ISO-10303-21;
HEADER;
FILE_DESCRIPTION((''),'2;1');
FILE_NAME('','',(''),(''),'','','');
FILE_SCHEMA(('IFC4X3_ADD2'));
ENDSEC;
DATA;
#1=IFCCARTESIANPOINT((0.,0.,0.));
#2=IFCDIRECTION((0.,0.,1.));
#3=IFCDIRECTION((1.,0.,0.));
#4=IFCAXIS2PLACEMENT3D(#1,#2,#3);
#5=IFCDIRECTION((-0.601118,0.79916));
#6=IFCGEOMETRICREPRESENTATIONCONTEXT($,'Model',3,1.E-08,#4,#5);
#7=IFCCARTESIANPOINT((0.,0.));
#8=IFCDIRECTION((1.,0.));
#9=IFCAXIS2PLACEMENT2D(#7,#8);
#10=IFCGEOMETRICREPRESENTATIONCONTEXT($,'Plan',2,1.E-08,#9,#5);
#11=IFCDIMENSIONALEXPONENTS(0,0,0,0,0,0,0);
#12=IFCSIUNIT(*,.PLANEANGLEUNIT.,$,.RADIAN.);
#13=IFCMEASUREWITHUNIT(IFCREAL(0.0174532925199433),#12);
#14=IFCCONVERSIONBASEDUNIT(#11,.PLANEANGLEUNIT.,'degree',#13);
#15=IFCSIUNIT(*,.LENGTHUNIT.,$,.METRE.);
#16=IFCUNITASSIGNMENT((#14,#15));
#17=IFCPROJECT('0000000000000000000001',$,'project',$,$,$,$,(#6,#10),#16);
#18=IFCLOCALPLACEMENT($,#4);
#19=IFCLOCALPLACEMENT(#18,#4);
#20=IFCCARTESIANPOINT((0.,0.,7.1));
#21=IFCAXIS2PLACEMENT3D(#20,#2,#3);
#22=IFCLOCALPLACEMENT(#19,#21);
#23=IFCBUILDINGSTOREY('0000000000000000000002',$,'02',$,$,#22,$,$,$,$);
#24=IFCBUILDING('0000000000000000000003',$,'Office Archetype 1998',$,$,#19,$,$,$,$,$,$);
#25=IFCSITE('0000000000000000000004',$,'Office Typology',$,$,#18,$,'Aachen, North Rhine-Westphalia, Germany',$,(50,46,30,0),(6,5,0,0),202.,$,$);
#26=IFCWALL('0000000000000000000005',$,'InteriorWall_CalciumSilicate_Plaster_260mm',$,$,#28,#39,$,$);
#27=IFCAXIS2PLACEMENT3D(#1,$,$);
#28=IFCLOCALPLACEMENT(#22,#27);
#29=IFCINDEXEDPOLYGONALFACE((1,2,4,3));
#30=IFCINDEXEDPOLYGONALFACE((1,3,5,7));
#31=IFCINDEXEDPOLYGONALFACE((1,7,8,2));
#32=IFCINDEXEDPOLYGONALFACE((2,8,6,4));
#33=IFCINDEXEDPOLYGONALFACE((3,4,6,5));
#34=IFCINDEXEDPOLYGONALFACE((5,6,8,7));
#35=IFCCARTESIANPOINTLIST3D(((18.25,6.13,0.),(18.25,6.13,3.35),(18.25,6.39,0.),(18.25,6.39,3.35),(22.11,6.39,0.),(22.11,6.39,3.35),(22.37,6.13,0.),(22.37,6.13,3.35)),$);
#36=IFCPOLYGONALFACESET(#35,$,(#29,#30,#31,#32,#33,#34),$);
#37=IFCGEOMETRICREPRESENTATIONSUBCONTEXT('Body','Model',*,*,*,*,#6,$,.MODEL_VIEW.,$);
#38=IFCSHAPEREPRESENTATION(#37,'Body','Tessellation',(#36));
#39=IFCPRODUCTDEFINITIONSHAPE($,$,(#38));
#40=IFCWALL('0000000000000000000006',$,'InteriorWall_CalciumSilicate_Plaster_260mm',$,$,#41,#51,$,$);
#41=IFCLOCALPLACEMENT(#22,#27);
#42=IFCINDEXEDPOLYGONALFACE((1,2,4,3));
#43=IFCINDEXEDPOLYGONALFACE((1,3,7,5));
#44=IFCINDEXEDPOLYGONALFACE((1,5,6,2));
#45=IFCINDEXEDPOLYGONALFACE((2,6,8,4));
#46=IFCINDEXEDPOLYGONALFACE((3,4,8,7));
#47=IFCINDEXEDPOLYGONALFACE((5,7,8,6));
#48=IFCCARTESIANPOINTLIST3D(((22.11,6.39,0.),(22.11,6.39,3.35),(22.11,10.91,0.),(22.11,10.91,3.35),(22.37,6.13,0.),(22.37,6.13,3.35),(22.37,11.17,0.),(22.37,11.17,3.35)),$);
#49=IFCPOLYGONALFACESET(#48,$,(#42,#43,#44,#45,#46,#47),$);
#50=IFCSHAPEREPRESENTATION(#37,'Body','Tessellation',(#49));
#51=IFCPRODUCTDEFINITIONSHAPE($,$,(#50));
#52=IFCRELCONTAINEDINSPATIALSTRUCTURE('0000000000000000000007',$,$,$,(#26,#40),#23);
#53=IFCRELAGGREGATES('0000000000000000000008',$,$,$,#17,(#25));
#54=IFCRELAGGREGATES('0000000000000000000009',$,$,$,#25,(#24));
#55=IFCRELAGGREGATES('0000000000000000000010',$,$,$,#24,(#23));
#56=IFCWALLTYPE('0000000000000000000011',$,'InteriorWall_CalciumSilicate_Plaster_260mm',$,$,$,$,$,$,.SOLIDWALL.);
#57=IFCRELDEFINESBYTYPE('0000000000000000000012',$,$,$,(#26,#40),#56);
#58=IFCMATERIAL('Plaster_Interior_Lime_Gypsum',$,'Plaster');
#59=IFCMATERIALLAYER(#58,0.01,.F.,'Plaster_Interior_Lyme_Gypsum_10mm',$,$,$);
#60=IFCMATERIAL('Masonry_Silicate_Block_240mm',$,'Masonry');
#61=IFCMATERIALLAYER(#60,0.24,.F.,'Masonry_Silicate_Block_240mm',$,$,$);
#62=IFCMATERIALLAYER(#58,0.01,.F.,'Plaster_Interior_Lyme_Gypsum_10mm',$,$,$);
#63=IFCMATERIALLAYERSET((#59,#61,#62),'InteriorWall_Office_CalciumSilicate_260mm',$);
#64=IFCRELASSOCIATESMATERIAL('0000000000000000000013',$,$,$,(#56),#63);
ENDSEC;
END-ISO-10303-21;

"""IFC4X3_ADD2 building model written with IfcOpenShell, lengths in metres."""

from ifc_helpers import new_model, entity, si_unit, converted_unit, direction, frame, origin_with_axes, origin_2d_with_axis, place, context, subcontext, project, spatial, line, indexed_curve, outline, extrude, material, layer, layer_set, type_object, element, save


model = new_model("IFC4X3_ADD2")

# Units and contexts
model_context = context("Model", 3, precision=1e-08, world=origin_with_axes(), true_north=direction((-0.601118, 0.79916)))
plan_context = context("Plan", 2, precision=1e-08, world=origin_2d_with_axis(), true_north=direction((-0.601118, 0.79916)))
body_context = subcontext(model_context, "Body", "Model", "MODEL_VIEW")
ifc_project = project(units=[converted_unit("PLANEANGLEUNIT", "degree", entity("IfcReal", 0.0174532925199433), si_unit("PLANEANGLEUNIT", "RADIAN"), dimensions=[0, 0, 0, 0, 0, 0, 0]), si_unit("LENGTHUNIT", "METRE")], contexts=[model_context, plan_context])

# Site, building, storey
site_placement = place(None, origin_with_axes())
site = spatial("IfcSite", under=ifc_project, at=site_placement, Name="Office Typology", LongName="Aachen, North Rhine-Westphalia, Germany", RefLatitude=(50, 46, 30, 0), RefLongitude=(6, 5, 0, 0), RefElevation=202.0)
building_placement = place(site_placement, origin_with_axes())
building = spatial("IfcBuilding", under=site, at=building_placement, Name="Office Archetype 1998")
storey_placement = place(building_placement, frame((0.0, 0.0, 7.1), z_axis=(0.0, 0.0, 1.0), x_axis=(1.0, 0.0, 0.0)))
storey = spatial("IfcBuildingStorey", under=building, at=storey_placement, Name="02")

# Wall
ifc_material_1 = material(Name="Plaster_Interior_Lime_Gypsum", Category="Plaster")
ifc_layer_1 = layer(ifc_material_1, 0.01, ventilated=False, Name="Plaster_Interior_Lyme_Gypsum_10mm")
ifc_material_2 = material(Name="Masonry_Silicate_Block_240mm", Category="Masonry")
ifc_layer_2 = layer(ifc_material_2, 0.24, ventilated=False, Name="Masonry_Silicate_Block_240mm")
ifc_layer_3 = layer(ifc_material_1, 0.01, ventilated=False, Name="Plaster_Interior_Lyme_Gypsum_10mm")
ifc_layer_set_1 = layer_set([ifc_layer_1, ifc_layer_2, ifc_layer_3], Name="InteriorWall_Office_CalciumSilicate_260mm")
wall_type_1 = type_object("IfcWallType", Name="InteriorWall_CalciumSilicate_Plaster_260mm", PredefinedType="SOLIDWALL", material=ifc_layer_set_1)
wall_1_placement = place(storey_placement, frame((18.25, 6.13, 0.0), z_axis=(0.0, 0.0, 1.0), x_axis=(1.0, 0.0, 0.0)))
element("IfcWall", 1, at=wall_1_placement, inside=storey, type_object=wall_type_1, Name="InteriorWall_CalciumSilicate_Plaster_260mm", context=body_context, shape_type="SweptSolid", body=[
    extrude(outline(indexed_curve([(0.0, 0.0), (0.0, 0.26), (3.86, 0.26), (4.12, 0.0)], segments=[line(1, 2, 3, 4, 1)])), origin_with_axes(), (0.0, 0.0, 1.0), 3.35),
])

# Wall
wall_2_placement = place(storey_placement, frame((22.37, 6.13, 0.0), z_axis=(0.0, 0.0, 1.0), x_axis=(0.0, 1.0, 0.0)))
element("IfcWall", 2, at=wall_2_placement, inside=storey, type_object=wall_type_1, Name="InteriorWall_CalciumSilicate_Plaster_260mm", context=body_context, shape_type="SweptSolid", body=[
    extrude(outline(indexed_curve([(0.0, 0.0), (0.26, 0.26), (4.78, 0.26), (5.04, 0.0)], segments=[line(1, 2, 3, 4, 1)])), origin_with_axes(), (0.0, 0.0, 1.0), 3.35),
])

save(model, "model.ifc")
